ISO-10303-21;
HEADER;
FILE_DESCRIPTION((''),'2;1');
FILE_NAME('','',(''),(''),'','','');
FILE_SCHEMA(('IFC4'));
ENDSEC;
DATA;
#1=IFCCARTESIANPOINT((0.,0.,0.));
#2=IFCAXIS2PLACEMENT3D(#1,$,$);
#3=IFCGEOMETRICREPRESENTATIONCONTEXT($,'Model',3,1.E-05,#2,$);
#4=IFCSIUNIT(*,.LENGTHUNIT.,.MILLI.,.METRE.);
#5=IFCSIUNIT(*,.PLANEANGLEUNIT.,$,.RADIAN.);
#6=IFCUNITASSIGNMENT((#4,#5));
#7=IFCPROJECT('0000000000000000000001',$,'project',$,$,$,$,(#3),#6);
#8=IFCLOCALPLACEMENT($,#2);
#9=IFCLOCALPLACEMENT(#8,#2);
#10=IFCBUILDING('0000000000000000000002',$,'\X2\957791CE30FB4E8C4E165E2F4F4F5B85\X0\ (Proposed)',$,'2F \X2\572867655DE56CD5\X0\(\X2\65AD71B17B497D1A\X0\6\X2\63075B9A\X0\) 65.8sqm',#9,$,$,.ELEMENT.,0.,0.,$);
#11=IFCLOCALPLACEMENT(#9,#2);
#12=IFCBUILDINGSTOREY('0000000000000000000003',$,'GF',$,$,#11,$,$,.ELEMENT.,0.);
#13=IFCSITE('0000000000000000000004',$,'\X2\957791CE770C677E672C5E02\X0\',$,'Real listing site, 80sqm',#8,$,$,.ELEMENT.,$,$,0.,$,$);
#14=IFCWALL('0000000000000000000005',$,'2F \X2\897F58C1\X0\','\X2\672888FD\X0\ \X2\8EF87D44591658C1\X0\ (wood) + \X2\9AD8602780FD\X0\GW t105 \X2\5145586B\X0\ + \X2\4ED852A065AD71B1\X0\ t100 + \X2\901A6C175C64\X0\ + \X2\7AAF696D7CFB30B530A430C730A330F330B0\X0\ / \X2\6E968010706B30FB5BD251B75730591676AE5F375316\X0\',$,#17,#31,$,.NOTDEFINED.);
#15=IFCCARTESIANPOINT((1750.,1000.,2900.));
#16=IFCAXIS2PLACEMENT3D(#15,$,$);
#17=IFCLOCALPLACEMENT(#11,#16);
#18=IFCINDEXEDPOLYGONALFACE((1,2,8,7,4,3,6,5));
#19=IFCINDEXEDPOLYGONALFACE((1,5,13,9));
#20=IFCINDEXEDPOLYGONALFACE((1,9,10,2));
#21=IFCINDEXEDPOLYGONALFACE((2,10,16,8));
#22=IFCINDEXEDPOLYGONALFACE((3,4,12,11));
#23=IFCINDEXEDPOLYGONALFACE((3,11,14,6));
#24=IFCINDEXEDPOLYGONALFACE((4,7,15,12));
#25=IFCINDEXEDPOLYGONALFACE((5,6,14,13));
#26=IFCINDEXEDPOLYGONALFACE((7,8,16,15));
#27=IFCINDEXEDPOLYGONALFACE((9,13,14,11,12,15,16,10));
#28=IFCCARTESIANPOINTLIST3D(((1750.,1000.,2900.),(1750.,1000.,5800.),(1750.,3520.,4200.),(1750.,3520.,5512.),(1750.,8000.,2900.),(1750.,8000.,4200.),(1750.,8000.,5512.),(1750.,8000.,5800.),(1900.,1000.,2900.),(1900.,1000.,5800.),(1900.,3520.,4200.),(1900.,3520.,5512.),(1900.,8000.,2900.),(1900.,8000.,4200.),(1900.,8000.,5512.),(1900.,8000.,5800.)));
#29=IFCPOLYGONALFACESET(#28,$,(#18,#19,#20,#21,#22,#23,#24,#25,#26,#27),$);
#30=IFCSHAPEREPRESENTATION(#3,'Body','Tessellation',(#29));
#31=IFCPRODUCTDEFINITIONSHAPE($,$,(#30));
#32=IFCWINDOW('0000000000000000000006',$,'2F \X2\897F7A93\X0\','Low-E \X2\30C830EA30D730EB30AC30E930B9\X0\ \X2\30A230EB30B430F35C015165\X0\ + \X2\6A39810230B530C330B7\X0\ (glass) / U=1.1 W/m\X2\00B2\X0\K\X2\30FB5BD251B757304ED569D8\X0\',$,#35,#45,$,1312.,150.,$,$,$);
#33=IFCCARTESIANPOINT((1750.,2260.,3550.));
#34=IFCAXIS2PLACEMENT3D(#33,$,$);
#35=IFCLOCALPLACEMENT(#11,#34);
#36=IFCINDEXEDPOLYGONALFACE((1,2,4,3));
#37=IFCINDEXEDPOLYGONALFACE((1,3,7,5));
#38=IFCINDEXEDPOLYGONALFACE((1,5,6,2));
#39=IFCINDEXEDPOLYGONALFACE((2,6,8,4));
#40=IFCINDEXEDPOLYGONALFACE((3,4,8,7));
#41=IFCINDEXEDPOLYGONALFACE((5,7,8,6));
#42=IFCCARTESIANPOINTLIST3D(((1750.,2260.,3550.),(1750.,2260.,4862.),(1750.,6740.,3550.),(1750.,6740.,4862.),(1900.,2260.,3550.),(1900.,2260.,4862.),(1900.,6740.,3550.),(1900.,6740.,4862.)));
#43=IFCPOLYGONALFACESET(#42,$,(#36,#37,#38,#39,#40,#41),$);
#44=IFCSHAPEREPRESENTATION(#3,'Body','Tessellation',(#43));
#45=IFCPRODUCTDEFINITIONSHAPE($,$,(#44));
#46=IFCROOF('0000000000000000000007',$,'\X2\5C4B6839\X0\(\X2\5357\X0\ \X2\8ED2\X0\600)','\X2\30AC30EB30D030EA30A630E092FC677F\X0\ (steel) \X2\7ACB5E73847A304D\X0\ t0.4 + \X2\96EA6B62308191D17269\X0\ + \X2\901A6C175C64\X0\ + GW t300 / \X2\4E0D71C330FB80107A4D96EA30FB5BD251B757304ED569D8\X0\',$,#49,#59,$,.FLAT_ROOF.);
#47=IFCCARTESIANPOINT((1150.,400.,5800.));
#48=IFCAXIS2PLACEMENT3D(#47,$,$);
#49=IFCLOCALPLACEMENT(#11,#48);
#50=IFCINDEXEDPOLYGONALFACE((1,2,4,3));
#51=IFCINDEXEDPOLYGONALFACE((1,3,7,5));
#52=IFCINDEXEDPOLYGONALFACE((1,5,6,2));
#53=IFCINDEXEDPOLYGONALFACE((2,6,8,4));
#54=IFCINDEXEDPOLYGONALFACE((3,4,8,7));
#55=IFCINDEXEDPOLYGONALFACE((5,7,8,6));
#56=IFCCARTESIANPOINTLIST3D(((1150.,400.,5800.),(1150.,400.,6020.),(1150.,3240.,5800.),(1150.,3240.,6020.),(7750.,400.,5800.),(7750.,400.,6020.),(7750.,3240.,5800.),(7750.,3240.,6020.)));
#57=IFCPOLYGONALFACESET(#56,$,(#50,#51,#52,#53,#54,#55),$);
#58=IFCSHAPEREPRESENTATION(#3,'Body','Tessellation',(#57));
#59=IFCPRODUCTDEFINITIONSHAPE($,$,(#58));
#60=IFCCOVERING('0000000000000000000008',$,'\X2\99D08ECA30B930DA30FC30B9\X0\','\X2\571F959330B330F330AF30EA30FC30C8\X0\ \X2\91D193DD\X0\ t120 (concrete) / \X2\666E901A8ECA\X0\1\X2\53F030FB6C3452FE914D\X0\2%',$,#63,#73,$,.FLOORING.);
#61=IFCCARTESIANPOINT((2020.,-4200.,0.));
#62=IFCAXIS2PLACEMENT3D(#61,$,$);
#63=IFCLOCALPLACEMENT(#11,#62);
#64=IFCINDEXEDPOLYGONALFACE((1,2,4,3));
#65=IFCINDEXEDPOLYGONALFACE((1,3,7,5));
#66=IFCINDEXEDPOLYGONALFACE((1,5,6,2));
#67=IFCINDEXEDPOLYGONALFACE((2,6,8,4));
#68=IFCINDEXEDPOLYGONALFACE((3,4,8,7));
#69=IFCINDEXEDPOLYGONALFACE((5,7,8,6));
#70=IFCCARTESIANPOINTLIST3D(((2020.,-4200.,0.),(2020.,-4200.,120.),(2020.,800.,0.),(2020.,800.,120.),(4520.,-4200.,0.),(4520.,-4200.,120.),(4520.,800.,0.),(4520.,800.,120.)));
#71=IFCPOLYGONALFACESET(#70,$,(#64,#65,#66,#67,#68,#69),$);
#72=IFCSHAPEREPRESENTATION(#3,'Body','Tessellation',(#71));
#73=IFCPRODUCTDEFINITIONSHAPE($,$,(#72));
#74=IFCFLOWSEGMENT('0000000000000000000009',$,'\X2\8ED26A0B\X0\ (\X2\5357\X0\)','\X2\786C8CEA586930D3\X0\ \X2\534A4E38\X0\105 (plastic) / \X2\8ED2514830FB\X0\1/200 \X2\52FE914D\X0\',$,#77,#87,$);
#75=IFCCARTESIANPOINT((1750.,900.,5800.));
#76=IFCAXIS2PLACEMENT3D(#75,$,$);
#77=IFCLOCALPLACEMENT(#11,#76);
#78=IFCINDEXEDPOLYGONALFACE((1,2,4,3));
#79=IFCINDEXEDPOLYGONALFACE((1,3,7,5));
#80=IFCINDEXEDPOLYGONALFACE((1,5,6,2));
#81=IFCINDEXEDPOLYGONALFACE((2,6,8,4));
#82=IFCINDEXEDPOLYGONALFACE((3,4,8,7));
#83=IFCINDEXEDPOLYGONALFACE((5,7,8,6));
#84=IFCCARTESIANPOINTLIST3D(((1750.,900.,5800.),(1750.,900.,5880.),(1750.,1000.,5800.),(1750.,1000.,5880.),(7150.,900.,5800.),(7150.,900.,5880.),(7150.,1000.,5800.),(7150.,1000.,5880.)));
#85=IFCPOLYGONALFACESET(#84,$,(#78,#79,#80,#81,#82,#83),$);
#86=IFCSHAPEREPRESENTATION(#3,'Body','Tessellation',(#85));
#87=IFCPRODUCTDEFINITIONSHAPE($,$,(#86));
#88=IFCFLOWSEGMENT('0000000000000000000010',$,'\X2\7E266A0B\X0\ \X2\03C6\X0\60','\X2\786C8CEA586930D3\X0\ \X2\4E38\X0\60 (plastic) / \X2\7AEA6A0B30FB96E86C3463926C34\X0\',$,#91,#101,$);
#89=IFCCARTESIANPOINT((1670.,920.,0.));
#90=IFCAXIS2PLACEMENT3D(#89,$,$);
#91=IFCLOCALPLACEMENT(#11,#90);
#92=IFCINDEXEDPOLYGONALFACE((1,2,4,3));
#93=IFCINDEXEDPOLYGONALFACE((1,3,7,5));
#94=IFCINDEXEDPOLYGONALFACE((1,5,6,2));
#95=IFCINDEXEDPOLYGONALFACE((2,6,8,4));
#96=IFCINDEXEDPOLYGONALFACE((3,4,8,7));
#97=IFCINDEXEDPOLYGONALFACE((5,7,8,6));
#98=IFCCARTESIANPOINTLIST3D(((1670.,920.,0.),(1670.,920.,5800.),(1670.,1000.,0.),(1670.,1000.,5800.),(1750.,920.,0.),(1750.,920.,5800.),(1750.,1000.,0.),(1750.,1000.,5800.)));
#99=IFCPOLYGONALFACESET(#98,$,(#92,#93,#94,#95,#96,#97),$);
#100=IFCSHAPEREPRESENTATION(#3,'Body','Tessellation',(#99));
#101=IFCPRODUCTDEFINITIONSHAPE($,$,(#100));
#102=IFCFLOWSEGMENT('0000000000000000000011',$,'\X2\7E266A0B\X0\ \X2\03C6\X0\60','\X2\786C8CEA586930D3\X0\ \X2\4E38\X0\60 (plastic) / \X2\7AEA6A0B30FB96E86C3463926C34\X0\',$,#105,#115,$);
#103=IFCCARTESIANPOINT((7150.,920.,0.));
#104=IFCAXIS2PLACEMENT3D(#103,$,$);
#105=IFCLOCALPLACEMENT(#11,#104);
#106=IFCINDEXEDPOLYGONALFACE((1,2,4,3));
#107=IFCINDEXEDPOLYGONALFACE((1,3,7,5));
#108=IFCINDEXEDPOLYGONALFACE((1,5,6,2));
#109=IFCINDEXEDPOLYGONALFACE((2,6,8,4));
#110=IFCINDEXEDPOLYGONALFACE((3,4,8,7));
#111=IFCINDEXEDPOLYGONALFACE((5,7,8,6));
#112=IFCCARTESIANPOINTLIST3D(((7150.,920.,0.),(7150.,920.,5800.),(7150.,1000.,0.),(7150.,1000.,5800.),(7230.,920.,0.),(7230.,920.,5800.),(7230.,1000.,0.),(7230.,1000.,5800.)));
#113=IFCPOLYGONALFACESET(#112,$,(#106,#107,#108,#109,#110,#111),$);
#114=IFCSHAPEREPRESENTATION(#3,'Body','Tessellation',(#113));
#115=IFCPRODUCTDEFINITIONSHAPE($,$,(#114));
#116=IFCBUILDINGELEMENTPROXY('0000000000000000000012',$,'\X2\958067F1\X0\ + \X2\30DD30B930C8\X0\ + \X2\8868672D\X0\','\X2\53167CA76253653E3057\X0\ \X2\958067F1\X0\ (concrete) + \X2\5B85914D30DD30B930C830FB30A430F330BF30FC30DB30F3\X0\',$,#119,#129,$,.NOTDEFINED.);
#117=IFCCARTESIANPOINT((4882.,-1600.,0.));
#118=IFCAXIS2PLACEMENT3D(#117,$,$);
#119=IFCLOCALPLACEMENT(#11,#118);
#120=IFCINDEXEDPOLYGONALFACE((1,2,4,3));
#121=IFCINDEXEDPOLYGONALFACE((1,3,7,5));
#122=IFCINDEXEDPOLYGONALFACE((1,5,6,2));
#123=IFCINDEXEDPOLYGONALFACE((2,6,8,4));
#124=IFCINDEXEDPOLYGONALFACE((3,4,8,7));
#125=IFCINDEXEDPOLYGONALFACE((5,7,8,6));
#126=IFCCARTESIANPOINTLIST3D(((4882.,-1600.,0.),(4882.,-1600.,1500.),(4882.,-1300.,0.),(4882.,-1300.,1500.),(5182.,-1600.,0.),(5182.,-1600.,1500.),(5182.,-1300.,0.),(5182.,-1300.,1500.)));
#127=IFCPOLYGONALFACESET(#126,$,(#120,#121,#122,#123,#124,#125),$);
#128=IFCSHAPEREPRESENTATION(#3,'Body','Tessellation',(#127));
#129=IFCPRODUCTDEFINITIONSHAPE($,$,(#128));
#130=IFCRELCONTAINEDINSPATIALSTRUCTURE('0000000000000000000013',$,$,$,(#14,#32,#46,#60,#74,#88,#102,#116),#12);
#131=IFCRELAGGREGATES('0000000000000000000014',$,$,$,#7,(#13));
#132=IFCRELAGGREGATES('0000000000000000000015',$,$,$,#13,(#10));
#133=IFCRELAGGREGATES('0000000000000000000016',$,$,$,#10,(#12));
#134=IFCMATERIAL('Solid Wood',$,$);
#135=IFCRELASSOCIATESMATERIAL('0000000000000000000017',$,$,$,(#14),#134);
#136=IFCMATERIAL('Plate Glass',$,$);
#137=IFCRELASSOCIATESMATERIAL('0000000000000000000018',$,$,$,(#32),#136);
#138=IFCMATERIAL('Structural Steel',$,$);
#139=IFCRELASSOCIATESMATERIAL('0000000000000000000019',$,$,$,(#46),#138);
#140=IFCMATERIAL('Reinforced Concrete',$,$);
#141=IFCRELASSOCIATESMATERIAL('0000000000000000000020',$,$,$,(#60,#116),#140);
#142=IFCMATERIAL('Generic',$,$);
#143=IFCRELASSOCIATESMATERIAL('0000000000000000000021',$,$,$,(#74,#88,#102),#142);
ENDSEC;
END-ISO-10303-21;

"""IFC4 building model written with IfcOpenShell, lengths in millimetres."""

from ifc_helpers import new_model, si_unit, frame, frame_2d, origin, place, context, project, spatial, rectangle, extrude, material, element, fill, save


model = new_model("IFC4")

# Units and contexts
model_context = context("Model", 3, precision=1e-05, world=origin())
ifc_project = project(units=[si_unit("LENGTHUNIT", "METRE", prefix="MILLI"), si_unit("PLANEANGLEUNIT", "RADIAN")], contexts=[model_context])

# Site, building, storey
site_placement = place(None, origin())
site = spatial("IfcSite", under=ifc_project, at=site_placement, Name="長野県松本市", ObjectType="Real listing site, 80sqm", CompositionType="ELEMENT", RefElevation=0.0)
building_placement = place(site_placement, origin())
building = spatial("IfcBuilding", under=site, at=building_placement, Name="長野・二世帯住宅 (Proposed)", ObjectType="2F 在来工法(断熱等級6指定) 65.8sqm", CompositionType="ELEMENT", ElevationOfRefHeight=0.0, ElevationOfTerrain=0.0)
storey_placement = place(building_placement, origin())
storey = spatial("IfcBuildingStorey", under=building, at=storey_placement, Name="GF", CompositionType="ELEMENT", Elevation=0.0)

# Shared definitions
ifc_material_1 = material(Name="Solid Wood")

# Shared definitions
ifc_material_2 = material(Name="Reinforced Concrete")

# Shared definitions
ifc_material_3 = material(Name="Plate Glass")

# Wall, opening, window
wall_1_placement = place(storey_placement, frame((1750.0, 1000.0, 2900.0)))
wall_1 = element("IfcWall", 1, at=wall_1_placement, inside=storey, material=ifc_material_1, Name="2F 西壁", Description="木製 軸組外壁 (wood) + 高性能GW t105 充填 + 付加断熱 t100 + 通気層 + 窯業系サイディング / 準耐火・寒冷地外皮強化", PredefinedType="NOTDEFINED", context=model_context, shape_type="SweptSolid", body=[
    extrude(rectangle(XDim=150.0, YDim=7000.0, at=frame_2d((75.0, 3500.0))), frame((1750.0, 1000.0, 2900.0)), (0.0, 0.0, 1.0), 2900.0),
])
opening_1_placement = place(storey_placement, frame((1750.0, 2260.0, 3550.0)))
opening_1 = element("IfcOpeningElement", 2, at=opening_1_placement, cuts=wall_1, PredefinedType="NOTDEFINED", context=model_context, shape_type="SweptSolid", body=[
    extrude(rectangle(XDim=150.0, YDim=4480.0, at=frame_2d((75.0, 2240.0))), frame((1750.0, 2260.0, 3550.0)), (0.0, 0.0, 1.0), 1312.0),
])
window_1_placement = place(storey_placement, frame((1750.0, 2260.0, 3550.0)))
window_1 = element("IfcWindow", 3, at=window_1_placement, inside=storey, material=ifc_material_3, Name="2F 西窓", Description="Low-E トリプルガラス アルゴン封入 + 樹脂サッシ (glass) / U=1.1 W/m²K・寒冷地仕様", OverallHeight=1312.0, OverallWidth=150.0, context=model_context, shape_type="SweptSolid", body=[
    extrude(rectangle(XDim=150.0, YDim=4480.0, at=frame_2d((75.0, 2240.0))), frame((1750.0, 2260.0, 3550.0)), (0.0, 0.0, 1.0), 1312.0),
])
fill(opening_1, window_1)

# Roof
ifc_material_4 = material(Name="Structural Steel")
for number, where, name in (
    (4, (1150.0, 400.0, 5800.0), "屋根(南 軒600)"),
):
    element("IfcRoof", number, at=place(storey_placement, frame(where)), inside=storey, material=ifc_material_4, Name=name, Description="ガルバリウム鋼板 (steel) 立平葺き t0.4 + 雪止め金物 + 通気層 + GW t300 / 不燃・耐積雪・寒冷地仕様", PredefinedType="FLAT_ROOF", context=model_context, shape_type="SweptSolid", body=[
        extrude(rectangle(XDim=6600.0, YDim=2840.0, at=frame_2d((3300.0, 1420.0))), frame((1150.0, 400.0, 5800.0)), (0.0, 0.0, 1.0), 220.0),
    ])

# Covering
covering_1_placement = place(storey_placement, frame((2020.0, -4200.0, 0.0)))
element("IfcCovering", 5, at=covering_1_placement, inside=storey, material=ifc_material_2, Name="駐車スペース", Description="土間コンクリート 金鏝 t120 (concrete) / 普通車1台・水勾配2%", PredefinedType="FLOORING", context=model_context, shape_type="SweptSolid", body=[
    extrude(rectangle(XDim=2500.0, YDim=5000.0, at=frame_2d((1250.0, 2500.0))), frame((2020.0, -4200.0, 0.0)), (0.0, 0.0, 1.0), 120.0),
])

# Flow segments
ifc_material_5 = material(Name="Generic")
flow_segment_1_placement = place(storey_placement, frame((1750.0, 900.0, 5800.0)))
element("IfcFlowSegment", 6, at=flow_segment_1_placement, inside=storey, material=ifc_material_5, Name="軒樋 (南)", Description="硬質塩ビ 半丸105 (plastic) / 軒先・1/200 勾配", context=model_context, shape_type="SweptSolid", body=[
    extrude(rectangle(XDim=5400.0, YDim=100.0, at=frame_2d((2700.0, 50.0))), frame((1750.0, 900.0, 5800.0)), (0.0, 0.0, 1.0), 80.0),
])
flow_segment_2_placement = place(storey_placement, frame((1670.0, 920.0, 0.0)))
element("IfcFlowSegment", 7, at=flow_segment_2_placement, inside=storey, material=ifc_material_5, Name="縦樋 φ60", Description="硬質塩ビ 丸60 (plastic) / 竪樋・雨水排水", context=model_context, shape_type="SweptSolid", body=[
    extrude(rectangle(XDim=80.0, YDim=80.0, at=frame_2d((40.0, 40.0))), frame((1670.0, 920.0, 0.0)), (0.0, 0.0, 1.0), 5800.0),
])
flow_segment_3_placement = place(storey_placement, frame((7150.0, 920.0, 0.0)))
element("IfcFlowSegment", 8, at=flow_segment_3_placement, inside=storey, material=ifc_material_5, Name="縦樋 φ60", Description="硬質塩ビ 丸60 (plastic) / 竪樋・雨水排水", context=model_context, shape_type="SweptSolid", body=[
    extrude(rectangle(XDim=80.0, YDim=80.0, at=frame_2d((40.0, 40.0))), frame((7150.0, 920.0, 0.0)), (0.0, 0.0, 1.0), 5800.0),
])

# Building element proxy
proxy_placement = place(storey_placement, frame((4882.0, -1600.0, 0.0)))
element("IfcBuildingElementProxy", 9, at=proxy_placement, inside=storey, material=ifc_material_2, Name="門柱 + ポスト + 表札", Description="化粧打放し 門柱 (concrete) + 宅配ポスト・インターホン", PredefinedType="NOTDEFINED", context=model_context, shape_type="SweptSolid", body=[
    extrude(rectangle(XDim=300.0, YDim=300.0, at=frame_2d((150.0, 150.0))), frame((4882.0, -1600.0, 0.0)), (0.0, 0.0, 1.0), 1500.0),
])

save(model, "model.ifc")
